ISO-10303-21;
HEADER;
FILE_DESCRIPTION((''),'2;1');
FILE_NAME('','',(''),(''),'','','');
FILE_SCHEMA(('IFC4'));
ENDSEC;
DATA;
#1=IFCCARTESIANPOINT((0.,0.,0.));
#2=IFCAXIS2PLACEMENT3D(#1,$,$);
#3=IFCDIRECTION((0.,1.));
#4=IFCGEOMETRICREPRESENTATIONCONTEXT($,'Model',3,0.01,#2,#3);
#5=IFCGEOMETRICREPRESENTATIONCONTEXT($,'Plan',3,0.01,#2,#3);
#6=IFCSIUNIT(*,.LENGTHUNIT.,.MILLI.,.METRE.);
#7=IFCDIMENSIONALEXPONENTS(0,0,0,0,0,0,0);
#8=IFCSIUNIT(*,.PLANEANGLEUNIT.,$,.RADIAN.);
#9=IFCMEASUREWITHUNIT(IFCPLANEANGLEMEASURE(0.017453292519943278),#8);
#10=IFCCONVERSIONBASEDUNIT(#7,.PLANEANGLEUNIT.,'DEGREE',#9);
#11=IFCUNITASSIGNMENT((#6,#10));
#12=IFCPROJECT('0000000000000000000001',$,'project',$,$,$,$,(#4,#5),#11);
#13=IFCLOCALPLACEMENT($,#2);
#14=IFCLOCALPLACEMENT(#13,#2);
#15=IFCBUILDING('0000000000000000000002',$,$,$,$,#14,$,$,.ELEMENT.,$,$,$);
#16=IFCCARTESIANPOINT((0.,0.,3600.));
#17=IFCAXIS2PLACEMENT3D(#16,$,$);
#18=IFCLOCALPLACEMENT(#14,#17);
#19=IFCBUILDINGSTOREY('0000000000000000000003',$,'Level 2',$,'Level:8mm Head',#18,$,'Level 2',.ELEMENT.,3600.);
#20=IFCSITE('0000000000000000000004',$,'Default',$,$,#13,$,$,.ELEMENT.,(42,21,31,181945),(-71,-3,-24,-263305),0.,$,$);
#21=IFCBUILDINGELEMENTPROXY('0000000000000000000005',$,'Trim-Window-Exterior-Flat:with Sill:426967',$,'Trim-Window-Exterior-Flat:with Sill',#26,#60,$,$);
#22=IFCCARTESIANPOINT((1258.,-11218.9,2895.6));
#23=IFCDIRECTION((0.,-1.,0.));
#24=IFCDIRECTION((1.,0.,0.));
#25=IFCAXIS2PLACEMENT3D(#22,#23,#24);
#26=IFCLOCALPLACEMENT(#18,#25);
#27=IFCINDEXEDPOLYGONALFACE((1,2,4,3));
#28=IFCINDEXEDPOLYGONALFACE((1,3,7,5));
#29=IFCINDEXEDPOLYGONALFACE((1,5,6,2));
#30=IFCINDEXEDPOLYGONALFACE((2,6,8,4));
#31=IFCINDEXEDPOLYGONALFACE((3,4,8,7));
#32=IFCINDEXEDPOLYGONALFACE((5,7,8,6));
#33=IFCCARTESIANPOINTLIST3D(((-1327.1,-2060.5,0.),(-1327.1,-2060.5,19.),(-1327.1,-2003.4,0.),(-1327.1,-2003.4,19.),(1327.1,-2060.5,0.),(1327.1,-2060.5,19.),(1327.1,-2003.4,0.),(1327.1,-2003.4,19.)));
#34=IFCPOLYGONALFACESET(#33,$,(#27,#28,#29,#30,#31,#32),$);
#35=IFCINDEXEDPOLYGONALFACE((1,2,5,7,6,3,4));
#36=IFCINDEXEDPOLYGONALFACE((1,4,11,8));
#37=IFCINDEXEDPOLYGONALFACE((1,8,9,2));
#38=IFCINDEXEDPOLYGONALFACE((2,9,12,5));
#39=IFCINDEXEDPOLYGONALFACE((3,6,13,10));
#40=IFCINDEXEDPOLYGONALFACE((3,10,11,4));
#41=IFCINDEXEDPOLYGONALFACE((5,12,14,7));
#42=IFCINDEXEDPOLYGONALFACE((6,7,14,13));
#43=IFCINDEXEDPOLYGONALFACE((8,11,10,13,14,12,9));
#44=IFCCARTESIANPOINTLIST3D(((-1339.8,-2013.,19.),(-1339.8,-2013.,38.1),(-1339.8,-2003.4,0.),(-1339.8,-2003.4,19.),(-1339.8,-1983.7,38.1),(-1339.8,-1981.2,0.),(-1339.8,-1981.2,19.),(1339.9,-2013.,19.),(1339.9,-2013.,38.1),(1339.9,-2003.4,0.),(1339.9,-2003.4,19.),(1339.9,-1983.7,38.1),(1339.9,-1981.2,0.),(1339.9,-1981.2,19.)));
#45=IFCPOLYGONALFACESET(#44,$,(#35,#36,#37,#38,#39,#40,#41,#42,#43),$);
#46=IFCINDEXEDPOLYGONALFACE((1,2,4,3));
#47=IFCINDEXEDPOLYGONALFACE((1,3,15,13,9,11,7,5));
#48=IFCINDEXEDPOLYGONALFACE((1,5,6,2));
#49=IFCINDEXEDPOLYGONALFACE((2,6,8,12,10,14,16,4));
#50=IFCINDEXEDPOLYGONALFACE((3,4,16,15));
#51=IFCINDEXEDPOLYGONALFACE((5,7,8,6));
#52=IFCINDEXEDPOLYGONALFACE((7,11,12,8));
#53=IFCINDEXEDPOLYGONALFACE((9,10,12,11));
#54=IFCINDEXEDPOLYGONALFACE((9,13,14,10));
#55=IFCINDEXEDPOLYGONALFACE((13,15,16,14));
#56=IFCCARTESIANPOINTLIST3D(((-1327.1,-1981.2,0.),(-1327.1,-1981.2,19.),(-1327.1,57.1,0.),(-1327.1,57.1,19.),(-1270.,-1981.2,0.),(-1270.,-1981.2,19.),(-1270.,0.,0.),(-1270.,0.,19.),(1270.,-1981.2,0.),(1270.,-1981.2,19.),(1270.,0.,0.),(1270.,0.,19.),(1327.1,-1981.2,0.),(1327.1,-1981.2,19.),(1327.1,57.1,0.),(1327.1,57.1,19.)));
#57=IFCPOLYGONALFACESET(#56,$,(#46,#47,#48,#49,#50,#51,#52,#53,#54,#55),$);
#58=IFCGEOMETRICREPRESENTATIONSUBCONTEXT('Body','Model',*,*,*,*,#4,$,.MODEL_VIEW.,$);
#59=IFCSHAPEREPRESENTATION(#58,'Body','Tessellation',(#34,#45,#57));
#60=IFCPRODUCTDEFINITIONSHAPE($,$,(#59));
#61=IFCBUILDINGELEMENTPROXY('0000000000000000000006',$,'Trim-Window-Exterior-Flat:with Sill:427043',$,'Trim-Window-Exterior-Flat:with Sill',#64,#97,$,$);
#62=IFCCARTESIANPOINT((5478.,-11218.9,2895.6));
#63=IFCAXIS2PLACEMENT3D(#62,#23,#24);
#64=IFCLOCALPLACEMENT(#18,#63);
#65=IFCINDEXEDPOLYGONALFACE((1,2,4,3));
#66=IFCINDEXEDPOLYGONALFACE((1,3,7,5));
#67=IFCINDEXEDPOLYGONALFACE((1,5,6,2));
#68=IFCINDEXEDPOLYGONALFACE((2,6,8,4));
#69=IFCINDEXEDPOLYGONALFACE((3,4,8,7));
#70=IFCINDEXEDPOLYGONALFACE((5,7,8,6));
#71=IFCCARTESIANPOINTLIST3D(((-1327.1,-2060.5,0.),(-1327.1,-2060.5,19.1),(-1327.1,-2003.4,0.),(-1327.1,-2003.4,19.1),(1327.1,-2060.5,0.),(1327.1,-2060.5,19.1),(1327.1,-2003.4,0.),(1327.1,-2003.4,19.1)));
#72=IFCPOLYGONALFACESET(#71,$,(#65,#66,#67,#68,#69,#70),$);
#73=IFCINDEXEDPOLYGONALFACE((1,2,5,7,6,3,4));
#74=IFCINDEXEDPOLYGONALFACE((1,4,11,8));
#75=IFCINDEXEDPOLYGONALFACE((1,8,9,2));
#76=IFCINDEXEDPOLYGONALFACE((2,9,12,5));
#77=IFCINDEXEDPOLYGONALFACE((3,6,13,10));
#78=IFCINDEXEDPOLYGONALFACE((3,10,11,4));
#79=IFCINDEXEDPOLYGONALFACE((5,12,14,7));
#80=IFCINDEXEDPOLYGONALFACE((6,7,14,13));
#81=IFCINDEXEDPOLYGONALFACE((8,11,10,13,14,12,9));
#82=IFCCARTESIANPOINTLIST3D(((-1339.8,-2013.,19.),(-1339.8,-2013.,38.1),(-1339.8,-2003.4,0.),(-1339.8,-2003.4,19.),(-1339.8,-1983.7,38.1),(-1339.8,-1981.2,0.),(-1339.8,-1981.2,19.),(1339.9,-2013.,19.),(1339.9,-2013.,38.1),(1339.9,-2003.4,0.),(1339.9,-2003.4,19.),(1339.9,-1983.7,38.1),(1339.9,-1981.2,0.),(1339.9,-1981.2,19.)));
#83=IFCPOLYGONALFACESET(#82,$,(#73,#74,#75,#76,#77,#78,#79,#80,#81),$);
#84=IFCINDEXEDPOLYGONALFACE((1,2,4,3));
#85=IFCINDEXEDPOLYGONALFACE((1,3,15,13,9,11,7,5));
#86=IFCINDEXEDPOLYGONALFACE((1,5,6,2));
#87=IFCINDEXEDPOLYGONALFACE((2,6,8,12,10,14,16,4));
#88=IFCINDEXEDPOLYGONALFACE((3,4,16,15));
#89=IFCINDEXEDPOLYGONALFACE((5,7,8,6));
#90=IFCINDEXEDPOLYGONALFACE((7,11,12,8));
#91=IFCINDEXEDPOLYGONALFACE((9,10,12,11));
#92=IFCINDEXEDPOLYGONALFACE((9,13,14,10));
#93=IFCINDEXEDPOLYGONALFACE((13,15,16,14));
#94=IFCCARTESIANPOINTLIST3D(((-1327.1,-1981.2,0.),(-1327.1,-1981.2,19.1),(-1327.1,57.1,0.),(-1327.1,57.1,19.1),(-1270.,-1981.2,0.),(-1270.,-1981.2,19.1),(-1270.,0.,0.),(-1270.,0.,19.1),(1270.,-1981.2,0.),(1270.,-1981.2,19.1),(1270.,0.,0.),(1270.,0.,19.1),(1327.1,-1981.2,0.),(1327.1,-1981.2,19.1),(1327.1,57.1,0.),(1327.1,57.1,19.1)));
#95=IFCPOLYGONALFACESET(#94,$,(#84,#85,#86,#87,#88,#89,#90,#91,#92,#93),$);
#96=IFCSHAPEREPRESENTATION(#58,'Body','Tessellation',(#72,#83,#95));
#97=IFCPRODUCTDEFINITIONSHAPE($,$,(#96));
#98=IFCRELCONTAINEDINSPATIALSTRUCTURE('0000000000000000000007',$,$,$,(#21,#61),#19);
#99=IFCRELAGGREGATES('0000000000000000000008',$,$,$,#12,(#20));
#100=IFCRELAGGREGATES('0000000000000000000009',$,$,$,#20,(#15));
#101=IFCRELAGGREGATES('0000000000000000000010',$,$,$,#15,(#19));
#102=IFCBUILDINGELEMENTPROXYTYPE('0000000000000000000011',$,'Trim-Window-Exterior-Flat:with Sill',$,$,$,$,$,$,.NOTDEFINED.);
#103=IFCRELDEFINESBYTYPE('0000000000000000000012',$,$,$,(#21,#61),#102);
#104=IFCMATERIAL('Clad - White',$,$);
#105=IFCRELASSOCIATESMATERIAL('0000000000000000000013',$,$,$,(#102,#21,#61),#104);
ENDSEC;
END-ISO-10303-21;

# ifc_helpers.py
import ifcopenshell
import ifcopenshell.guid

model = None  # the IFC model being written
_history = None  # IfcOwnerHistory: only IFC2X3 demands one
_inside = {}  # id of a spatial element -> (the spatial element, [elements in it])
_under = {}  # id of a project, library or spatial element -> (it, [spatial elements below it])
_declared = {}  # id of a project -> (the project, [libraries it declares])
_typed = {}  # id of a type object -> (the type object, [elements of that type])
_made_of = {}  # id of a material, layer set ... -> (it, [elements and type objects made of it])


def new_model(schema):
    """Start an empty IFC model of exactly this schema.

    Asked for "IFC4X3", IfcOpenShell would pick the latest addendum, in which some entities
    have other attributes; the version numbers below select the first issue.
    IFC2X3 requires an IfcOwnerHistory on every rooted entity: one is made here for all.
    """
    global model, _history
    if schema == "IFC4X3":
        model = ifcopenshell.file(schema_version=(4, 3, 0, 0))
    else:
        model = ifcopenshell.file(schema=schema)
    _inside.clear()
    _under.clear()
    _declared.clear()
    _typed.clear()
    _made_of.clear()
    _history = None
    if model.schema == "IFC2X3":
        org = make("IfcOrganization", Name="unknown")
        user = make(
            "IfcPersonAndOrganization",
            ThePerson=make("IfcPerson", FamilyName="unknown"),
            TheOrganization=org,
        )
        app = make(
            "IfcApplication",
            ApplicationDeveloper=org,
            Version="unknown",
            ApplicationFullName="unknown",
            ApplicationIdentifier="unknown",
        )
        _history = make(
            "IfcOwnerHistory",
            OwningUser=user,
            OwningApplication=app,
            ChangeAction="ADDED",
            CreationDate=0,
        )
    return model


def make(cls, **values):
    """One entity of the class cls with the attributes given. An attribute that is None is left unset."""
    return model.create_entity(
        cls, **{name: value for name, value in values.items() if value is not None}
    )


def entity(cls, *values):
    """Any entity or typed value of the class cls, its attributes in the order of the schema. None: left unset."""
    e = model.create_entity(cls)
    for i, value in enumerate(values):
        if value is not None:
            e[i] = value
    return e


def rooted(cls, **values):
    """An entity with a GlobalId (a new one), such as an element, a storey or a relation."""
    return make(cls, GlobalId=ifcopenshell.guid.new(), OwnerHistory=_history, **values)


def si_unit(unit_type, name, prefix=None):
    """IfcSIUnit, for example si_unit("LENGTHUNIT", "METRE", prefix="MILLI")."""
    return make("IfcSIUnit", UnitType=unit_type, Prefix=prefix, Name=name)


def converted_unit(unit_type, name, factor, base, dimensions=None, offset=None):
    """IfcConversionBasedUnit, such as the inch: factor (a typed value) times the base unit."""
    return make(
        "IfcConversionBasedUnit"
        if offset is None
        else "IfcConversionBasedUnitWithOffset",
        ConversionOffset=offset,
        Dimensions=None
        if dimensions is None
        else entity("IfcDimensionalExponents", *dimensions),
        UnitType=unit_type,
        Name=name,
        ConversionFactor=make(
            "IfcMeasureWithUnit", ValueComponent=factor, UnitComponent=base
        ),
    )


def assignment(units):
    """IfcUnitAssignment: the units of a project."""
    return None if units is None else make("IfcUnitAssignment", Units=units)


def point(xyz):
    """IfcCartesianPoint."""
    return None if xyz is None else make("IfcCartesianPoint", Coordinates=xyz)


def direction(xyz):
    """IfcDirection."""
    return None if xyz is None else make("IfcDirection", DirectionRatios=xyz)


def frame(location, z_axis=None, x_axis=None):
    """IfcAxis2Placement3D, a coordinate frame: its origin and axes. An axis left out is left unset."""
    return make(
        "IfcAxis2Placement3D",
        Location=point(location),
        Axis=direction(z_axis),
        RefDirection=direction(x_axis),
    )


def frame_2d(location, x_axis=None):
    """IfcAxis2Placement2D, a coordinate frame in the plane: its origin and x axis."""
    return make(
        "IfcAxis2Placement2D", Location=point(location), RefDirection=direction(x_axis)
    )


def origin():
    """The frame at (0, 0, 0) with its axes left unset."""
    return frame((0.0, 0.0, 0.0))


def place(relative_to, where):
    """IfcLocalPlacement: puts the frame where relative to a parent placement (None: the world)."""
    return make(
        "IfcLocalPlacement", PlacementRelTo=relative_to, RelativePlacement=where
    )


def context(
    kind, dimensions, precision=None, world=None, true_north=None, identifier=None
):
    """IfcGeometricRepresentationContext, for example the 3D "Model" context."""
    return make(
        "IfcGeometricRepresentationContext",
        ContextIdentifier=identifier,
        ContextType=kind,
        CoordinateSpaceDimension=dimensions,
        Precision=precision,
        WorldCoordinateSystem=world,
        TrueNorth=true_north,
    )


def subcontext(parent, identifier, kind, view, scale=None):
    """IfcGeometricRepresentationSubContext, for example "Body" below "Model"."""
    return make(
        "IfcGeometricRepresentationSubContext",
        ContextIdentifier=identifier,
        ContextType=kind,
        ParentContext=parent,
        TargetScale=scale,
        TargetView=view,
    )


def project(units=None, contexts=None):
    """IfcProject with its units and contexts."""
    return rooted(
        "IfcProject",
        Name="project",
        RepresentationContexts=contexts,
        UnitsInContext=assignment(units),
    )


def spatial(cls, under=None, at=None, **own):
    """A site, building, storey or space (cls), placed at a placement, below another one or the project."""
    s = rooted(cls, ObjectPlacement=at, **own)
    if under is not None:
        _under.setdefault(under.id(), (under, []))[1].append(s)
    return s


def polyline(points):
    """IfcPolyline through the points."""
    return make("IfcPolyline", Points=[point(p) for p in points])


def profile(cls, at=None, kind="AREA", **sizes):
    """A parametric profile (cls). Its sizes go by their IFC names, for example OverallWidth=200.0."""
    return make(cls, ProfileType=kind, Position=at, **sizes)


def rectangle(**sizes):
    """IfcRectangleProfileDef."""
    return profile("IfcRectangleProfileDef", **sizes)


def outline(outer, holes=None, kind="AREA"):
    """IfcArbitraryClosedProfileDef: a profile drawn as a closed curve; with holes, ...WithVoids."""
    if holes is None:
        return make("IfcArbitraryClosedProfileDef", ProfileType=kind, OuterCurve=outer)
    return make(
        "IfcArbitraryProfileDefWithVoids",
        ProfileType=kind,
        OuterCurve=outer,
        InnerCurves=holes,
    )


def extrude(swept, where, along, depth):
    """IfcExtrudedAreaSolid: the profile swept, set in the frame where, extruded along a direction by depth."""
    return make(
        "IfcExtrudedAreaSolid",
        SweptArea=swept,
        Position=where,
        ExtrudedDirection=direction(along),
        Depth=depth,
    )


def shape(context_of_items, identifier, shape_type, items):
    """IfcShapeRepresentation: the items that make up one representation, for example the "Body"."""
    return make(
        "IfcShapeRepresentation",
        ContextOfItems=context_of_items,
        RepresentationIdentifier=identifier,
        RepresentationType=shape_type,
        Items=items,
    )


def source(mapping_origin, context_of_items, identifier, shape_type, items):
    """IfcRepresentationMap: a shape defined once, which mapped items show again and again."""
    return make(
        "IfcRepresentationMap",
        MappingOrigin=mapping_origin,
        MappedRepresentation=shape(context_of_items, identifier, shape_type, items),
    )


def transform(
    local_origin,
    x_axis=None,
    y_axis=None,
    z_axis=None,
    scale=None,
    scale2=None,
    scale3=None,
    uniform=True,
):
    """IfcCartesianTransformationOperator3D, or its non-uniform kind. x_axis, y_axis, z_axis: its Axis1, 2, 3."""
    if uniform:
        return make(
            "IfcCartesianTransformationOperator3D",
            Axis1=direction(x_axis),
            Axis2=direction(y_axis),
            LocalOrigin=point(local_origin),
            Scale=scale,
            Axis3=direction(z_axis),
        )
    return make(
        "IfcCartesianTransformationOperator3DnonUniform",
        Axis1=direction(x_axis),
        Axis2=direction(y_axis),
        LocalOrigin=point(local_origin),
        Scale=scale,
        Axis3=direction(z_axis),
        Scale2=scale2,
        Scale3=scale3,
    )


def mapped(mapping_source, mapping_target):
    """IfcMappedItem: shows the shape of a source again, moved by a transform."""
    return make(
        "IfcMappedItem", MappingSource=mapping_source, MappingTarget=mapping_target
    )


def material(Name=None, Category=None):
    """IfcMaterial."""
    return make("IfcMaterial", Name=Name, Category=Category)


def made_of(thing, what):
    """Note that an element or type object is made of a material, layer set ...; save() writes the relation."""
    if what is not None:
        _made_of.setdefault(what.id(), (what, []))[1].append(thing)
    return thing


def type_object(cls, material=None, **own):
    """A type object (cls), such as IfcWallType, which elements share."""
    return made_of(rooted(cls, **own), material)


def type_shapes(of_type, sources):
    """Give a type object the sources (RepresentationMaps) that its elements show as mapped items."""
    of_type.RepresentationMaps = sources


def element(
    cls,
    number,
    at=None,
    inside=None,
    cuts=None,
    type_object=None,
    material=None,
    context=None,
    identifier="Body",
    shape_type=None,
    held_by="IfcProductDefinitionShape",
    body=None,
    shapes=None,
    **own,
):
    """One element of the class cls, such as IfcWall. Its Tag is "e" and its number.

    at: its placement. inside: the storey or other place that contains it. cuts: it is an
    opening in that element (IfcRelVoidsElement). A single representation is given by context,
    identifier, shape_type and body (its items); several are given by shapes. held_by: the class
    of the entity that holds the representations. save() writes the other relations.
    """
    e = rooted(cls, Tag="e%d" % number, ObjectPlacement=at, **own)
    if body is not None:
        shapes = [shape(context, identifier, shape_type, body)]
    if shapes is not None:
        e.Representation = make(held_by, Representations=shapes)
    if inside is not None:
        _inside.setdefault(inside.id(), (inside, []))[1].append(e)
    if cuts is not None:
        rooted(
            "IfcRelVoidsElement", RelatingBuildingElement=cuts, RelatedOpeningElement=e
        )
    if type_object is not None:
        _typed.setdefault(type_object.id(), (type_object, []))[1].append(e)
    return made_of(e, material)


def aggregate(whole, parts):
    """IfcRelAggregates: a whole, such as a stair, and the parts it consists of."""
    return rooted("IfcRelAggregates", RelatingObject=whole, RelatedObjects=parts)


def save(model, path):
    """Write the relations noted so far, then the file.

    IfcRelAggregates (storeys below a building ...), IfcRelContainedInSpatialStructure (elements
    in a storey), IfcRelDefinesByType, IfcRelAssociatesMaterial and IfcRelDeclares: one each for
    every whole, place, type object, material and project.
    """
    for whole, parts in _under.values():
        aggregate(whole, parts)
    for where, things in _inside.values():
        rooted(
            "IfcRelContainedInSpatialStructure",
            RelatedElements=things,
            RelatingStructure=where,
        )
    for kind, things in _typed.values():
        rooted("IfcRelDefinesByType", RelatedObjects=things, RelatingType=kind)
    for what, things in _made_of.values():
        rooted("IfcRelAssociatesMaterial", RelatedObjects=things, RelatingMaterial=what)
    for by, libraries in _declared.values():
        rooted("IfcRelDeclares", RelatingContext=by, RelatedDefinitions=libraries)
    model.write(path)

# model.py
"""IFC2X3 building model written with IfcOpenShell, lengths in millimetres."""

from ifc_helpers import new_model, entity, si_unit, converted_unit, direction, frame, frame_2d, origin, place, context, subcontext, project, spatial, polyline, rectangle, outline, extrude, source, transform, mapped, material, type_object, type_shapes, element, save


model = new_model("IFC2X3")

# Units and contexts
model_context = context("Model", 3, precision=0.01, world=origin(), true_north=direction((0.0, 1.0)))
plan_context = context("Plan", 3, precision=0.01, world=origin(), true_north=direction((0.0, 1.0)))
body_context = subcontext(model_context, "Body", "Model", "MODEL_VIEW")
ifc_project = project(units=[si_unit("LENGTHUNIT", "METRE", prefix="MILLI"), converted_unit("PLANEANGLEUNIT", "DEGREE", entity("IfcPlaneAngleMeasure", 0.017453292519943278), si_unit("PLANEANGLEUNIT", "RADIAN"), dimensions=[0, 0, 0, 0, 0, 0, 0])], contexts=[model_context, plan_context])

# Site, building, storey
site_placement = place(None, origin())
site = spatial("IfcSite", under=ifc_project, at=site_placement, Name="Default", CompositionType="ELEMENT", RefLatitude=(42, 21, 31, 181945), RefLongitude=(-71, -3, -24, -263305), RefElevation=0.0)
building_placement = place(site_placement, origin())
building = spatial("IfcBuilding", under=site, at=building_placement, CompositionType="ELEMENT")
storey_placement = place(building_placement, frame((0.0, 0.0, 3600.0)))
storey = spatial("IfcBuildingStorey", under=building, at=storey_placement, Name="Level 2", ObjectType="Level:8mm Head", LongName="Level 2", CompositionType="ELEMENT", Elevation=3600.0)

# Building element proxies
ifc_material_1 = material(Name="Clad - White")
building_element_proxy_type_1 = type_object("IfcBuildingElementProxyType", Name="Trim-Window-Exterior-Flat:with Sill", PredefinedType="NOTDEFINED", material=ifc_material_1)
shared_shape_1 = source(origin(), body_context, "Body", "SweptSolid", [
    extrude(rectangle(XDim=2654.3, YDim=57.2, at=frame_2d((0.0, 0.0), x_axis=(1.0, 0.0))), frame((0.0, -2032.0, 0.0), z_axis=(0.0, 0.0, 1.0), x_axis=(-1.0, 0.0, 0.0)), (0.0, 0.0, 1.0), 19.0),
    extrude(outline(polyline([(-19.0, -16.0), (0.0, -16.0), (0.0, -6.4), (19.0, -6.4), (19.0, 15.8), (0.0, 15.8), (-19.0, 13.3), (-19.0, -16.0)])), frame((-1339.8, -1997.0, 19.0), z_axis=(1.0, 0.0, 0.0), x_axis=(0.0, 0.0, -1.0)), (0.0, 0.0, 1.0), 2679.7),
    extrude(outline(polyline([(-1033.5, -1327.1), (1004.9, -1327.1), (1004.9, -1270.0), (-976.3, -1270.0), (-976.3, 1270.0), (1004.9, 1270.0), (1004.9, 1327.1), (-1033.5, 1327.1), (-1033.5, -1327.1)])), frame((0.0, -976.3, 0.0), z_axis=(0.0, 0.0, 1.0), x_axis=(0.0, -1.0, 0.0)), (0.0, 0.0, 1.0), 19.0),
])
type_shapes(building_element_proxy_type_1, [shared_shape_1])
for number, where, z_axis, x_axis, name in (
    (1, (1258.0, -11218.9, 2895.6), (0.0, -1.0, 0.0), (1.0, 0.0, 0.0), "Trim-Window-Exterior-Flat:with Sill:426967"),
    (2, (5478.0, -11218.9, 2895.6), (0.0, -1.0, 0.0), (1.0, 0.0, 0.0), "Trim-Window-Exterior-Flat:with Sill:427043"),
):
    element("IfcBuildingElementProxy", number, at=place(storey_placement, frame(where, z_axis=z_axis, x_axis=x_axis)), inside=storey, type_object=building_element_proxy_type_1, material=ifc_material_1, Name=name, ObjectType="Trim-Window-Exterior-Flat:with Sill", context=body_context, shape_type="MappedRepresentation", body=[
        mapped(shared_shape_1, transform((0.0, 0.0, 0.0), scale=1.0)),
    ])

save(model, "model.ifc")
